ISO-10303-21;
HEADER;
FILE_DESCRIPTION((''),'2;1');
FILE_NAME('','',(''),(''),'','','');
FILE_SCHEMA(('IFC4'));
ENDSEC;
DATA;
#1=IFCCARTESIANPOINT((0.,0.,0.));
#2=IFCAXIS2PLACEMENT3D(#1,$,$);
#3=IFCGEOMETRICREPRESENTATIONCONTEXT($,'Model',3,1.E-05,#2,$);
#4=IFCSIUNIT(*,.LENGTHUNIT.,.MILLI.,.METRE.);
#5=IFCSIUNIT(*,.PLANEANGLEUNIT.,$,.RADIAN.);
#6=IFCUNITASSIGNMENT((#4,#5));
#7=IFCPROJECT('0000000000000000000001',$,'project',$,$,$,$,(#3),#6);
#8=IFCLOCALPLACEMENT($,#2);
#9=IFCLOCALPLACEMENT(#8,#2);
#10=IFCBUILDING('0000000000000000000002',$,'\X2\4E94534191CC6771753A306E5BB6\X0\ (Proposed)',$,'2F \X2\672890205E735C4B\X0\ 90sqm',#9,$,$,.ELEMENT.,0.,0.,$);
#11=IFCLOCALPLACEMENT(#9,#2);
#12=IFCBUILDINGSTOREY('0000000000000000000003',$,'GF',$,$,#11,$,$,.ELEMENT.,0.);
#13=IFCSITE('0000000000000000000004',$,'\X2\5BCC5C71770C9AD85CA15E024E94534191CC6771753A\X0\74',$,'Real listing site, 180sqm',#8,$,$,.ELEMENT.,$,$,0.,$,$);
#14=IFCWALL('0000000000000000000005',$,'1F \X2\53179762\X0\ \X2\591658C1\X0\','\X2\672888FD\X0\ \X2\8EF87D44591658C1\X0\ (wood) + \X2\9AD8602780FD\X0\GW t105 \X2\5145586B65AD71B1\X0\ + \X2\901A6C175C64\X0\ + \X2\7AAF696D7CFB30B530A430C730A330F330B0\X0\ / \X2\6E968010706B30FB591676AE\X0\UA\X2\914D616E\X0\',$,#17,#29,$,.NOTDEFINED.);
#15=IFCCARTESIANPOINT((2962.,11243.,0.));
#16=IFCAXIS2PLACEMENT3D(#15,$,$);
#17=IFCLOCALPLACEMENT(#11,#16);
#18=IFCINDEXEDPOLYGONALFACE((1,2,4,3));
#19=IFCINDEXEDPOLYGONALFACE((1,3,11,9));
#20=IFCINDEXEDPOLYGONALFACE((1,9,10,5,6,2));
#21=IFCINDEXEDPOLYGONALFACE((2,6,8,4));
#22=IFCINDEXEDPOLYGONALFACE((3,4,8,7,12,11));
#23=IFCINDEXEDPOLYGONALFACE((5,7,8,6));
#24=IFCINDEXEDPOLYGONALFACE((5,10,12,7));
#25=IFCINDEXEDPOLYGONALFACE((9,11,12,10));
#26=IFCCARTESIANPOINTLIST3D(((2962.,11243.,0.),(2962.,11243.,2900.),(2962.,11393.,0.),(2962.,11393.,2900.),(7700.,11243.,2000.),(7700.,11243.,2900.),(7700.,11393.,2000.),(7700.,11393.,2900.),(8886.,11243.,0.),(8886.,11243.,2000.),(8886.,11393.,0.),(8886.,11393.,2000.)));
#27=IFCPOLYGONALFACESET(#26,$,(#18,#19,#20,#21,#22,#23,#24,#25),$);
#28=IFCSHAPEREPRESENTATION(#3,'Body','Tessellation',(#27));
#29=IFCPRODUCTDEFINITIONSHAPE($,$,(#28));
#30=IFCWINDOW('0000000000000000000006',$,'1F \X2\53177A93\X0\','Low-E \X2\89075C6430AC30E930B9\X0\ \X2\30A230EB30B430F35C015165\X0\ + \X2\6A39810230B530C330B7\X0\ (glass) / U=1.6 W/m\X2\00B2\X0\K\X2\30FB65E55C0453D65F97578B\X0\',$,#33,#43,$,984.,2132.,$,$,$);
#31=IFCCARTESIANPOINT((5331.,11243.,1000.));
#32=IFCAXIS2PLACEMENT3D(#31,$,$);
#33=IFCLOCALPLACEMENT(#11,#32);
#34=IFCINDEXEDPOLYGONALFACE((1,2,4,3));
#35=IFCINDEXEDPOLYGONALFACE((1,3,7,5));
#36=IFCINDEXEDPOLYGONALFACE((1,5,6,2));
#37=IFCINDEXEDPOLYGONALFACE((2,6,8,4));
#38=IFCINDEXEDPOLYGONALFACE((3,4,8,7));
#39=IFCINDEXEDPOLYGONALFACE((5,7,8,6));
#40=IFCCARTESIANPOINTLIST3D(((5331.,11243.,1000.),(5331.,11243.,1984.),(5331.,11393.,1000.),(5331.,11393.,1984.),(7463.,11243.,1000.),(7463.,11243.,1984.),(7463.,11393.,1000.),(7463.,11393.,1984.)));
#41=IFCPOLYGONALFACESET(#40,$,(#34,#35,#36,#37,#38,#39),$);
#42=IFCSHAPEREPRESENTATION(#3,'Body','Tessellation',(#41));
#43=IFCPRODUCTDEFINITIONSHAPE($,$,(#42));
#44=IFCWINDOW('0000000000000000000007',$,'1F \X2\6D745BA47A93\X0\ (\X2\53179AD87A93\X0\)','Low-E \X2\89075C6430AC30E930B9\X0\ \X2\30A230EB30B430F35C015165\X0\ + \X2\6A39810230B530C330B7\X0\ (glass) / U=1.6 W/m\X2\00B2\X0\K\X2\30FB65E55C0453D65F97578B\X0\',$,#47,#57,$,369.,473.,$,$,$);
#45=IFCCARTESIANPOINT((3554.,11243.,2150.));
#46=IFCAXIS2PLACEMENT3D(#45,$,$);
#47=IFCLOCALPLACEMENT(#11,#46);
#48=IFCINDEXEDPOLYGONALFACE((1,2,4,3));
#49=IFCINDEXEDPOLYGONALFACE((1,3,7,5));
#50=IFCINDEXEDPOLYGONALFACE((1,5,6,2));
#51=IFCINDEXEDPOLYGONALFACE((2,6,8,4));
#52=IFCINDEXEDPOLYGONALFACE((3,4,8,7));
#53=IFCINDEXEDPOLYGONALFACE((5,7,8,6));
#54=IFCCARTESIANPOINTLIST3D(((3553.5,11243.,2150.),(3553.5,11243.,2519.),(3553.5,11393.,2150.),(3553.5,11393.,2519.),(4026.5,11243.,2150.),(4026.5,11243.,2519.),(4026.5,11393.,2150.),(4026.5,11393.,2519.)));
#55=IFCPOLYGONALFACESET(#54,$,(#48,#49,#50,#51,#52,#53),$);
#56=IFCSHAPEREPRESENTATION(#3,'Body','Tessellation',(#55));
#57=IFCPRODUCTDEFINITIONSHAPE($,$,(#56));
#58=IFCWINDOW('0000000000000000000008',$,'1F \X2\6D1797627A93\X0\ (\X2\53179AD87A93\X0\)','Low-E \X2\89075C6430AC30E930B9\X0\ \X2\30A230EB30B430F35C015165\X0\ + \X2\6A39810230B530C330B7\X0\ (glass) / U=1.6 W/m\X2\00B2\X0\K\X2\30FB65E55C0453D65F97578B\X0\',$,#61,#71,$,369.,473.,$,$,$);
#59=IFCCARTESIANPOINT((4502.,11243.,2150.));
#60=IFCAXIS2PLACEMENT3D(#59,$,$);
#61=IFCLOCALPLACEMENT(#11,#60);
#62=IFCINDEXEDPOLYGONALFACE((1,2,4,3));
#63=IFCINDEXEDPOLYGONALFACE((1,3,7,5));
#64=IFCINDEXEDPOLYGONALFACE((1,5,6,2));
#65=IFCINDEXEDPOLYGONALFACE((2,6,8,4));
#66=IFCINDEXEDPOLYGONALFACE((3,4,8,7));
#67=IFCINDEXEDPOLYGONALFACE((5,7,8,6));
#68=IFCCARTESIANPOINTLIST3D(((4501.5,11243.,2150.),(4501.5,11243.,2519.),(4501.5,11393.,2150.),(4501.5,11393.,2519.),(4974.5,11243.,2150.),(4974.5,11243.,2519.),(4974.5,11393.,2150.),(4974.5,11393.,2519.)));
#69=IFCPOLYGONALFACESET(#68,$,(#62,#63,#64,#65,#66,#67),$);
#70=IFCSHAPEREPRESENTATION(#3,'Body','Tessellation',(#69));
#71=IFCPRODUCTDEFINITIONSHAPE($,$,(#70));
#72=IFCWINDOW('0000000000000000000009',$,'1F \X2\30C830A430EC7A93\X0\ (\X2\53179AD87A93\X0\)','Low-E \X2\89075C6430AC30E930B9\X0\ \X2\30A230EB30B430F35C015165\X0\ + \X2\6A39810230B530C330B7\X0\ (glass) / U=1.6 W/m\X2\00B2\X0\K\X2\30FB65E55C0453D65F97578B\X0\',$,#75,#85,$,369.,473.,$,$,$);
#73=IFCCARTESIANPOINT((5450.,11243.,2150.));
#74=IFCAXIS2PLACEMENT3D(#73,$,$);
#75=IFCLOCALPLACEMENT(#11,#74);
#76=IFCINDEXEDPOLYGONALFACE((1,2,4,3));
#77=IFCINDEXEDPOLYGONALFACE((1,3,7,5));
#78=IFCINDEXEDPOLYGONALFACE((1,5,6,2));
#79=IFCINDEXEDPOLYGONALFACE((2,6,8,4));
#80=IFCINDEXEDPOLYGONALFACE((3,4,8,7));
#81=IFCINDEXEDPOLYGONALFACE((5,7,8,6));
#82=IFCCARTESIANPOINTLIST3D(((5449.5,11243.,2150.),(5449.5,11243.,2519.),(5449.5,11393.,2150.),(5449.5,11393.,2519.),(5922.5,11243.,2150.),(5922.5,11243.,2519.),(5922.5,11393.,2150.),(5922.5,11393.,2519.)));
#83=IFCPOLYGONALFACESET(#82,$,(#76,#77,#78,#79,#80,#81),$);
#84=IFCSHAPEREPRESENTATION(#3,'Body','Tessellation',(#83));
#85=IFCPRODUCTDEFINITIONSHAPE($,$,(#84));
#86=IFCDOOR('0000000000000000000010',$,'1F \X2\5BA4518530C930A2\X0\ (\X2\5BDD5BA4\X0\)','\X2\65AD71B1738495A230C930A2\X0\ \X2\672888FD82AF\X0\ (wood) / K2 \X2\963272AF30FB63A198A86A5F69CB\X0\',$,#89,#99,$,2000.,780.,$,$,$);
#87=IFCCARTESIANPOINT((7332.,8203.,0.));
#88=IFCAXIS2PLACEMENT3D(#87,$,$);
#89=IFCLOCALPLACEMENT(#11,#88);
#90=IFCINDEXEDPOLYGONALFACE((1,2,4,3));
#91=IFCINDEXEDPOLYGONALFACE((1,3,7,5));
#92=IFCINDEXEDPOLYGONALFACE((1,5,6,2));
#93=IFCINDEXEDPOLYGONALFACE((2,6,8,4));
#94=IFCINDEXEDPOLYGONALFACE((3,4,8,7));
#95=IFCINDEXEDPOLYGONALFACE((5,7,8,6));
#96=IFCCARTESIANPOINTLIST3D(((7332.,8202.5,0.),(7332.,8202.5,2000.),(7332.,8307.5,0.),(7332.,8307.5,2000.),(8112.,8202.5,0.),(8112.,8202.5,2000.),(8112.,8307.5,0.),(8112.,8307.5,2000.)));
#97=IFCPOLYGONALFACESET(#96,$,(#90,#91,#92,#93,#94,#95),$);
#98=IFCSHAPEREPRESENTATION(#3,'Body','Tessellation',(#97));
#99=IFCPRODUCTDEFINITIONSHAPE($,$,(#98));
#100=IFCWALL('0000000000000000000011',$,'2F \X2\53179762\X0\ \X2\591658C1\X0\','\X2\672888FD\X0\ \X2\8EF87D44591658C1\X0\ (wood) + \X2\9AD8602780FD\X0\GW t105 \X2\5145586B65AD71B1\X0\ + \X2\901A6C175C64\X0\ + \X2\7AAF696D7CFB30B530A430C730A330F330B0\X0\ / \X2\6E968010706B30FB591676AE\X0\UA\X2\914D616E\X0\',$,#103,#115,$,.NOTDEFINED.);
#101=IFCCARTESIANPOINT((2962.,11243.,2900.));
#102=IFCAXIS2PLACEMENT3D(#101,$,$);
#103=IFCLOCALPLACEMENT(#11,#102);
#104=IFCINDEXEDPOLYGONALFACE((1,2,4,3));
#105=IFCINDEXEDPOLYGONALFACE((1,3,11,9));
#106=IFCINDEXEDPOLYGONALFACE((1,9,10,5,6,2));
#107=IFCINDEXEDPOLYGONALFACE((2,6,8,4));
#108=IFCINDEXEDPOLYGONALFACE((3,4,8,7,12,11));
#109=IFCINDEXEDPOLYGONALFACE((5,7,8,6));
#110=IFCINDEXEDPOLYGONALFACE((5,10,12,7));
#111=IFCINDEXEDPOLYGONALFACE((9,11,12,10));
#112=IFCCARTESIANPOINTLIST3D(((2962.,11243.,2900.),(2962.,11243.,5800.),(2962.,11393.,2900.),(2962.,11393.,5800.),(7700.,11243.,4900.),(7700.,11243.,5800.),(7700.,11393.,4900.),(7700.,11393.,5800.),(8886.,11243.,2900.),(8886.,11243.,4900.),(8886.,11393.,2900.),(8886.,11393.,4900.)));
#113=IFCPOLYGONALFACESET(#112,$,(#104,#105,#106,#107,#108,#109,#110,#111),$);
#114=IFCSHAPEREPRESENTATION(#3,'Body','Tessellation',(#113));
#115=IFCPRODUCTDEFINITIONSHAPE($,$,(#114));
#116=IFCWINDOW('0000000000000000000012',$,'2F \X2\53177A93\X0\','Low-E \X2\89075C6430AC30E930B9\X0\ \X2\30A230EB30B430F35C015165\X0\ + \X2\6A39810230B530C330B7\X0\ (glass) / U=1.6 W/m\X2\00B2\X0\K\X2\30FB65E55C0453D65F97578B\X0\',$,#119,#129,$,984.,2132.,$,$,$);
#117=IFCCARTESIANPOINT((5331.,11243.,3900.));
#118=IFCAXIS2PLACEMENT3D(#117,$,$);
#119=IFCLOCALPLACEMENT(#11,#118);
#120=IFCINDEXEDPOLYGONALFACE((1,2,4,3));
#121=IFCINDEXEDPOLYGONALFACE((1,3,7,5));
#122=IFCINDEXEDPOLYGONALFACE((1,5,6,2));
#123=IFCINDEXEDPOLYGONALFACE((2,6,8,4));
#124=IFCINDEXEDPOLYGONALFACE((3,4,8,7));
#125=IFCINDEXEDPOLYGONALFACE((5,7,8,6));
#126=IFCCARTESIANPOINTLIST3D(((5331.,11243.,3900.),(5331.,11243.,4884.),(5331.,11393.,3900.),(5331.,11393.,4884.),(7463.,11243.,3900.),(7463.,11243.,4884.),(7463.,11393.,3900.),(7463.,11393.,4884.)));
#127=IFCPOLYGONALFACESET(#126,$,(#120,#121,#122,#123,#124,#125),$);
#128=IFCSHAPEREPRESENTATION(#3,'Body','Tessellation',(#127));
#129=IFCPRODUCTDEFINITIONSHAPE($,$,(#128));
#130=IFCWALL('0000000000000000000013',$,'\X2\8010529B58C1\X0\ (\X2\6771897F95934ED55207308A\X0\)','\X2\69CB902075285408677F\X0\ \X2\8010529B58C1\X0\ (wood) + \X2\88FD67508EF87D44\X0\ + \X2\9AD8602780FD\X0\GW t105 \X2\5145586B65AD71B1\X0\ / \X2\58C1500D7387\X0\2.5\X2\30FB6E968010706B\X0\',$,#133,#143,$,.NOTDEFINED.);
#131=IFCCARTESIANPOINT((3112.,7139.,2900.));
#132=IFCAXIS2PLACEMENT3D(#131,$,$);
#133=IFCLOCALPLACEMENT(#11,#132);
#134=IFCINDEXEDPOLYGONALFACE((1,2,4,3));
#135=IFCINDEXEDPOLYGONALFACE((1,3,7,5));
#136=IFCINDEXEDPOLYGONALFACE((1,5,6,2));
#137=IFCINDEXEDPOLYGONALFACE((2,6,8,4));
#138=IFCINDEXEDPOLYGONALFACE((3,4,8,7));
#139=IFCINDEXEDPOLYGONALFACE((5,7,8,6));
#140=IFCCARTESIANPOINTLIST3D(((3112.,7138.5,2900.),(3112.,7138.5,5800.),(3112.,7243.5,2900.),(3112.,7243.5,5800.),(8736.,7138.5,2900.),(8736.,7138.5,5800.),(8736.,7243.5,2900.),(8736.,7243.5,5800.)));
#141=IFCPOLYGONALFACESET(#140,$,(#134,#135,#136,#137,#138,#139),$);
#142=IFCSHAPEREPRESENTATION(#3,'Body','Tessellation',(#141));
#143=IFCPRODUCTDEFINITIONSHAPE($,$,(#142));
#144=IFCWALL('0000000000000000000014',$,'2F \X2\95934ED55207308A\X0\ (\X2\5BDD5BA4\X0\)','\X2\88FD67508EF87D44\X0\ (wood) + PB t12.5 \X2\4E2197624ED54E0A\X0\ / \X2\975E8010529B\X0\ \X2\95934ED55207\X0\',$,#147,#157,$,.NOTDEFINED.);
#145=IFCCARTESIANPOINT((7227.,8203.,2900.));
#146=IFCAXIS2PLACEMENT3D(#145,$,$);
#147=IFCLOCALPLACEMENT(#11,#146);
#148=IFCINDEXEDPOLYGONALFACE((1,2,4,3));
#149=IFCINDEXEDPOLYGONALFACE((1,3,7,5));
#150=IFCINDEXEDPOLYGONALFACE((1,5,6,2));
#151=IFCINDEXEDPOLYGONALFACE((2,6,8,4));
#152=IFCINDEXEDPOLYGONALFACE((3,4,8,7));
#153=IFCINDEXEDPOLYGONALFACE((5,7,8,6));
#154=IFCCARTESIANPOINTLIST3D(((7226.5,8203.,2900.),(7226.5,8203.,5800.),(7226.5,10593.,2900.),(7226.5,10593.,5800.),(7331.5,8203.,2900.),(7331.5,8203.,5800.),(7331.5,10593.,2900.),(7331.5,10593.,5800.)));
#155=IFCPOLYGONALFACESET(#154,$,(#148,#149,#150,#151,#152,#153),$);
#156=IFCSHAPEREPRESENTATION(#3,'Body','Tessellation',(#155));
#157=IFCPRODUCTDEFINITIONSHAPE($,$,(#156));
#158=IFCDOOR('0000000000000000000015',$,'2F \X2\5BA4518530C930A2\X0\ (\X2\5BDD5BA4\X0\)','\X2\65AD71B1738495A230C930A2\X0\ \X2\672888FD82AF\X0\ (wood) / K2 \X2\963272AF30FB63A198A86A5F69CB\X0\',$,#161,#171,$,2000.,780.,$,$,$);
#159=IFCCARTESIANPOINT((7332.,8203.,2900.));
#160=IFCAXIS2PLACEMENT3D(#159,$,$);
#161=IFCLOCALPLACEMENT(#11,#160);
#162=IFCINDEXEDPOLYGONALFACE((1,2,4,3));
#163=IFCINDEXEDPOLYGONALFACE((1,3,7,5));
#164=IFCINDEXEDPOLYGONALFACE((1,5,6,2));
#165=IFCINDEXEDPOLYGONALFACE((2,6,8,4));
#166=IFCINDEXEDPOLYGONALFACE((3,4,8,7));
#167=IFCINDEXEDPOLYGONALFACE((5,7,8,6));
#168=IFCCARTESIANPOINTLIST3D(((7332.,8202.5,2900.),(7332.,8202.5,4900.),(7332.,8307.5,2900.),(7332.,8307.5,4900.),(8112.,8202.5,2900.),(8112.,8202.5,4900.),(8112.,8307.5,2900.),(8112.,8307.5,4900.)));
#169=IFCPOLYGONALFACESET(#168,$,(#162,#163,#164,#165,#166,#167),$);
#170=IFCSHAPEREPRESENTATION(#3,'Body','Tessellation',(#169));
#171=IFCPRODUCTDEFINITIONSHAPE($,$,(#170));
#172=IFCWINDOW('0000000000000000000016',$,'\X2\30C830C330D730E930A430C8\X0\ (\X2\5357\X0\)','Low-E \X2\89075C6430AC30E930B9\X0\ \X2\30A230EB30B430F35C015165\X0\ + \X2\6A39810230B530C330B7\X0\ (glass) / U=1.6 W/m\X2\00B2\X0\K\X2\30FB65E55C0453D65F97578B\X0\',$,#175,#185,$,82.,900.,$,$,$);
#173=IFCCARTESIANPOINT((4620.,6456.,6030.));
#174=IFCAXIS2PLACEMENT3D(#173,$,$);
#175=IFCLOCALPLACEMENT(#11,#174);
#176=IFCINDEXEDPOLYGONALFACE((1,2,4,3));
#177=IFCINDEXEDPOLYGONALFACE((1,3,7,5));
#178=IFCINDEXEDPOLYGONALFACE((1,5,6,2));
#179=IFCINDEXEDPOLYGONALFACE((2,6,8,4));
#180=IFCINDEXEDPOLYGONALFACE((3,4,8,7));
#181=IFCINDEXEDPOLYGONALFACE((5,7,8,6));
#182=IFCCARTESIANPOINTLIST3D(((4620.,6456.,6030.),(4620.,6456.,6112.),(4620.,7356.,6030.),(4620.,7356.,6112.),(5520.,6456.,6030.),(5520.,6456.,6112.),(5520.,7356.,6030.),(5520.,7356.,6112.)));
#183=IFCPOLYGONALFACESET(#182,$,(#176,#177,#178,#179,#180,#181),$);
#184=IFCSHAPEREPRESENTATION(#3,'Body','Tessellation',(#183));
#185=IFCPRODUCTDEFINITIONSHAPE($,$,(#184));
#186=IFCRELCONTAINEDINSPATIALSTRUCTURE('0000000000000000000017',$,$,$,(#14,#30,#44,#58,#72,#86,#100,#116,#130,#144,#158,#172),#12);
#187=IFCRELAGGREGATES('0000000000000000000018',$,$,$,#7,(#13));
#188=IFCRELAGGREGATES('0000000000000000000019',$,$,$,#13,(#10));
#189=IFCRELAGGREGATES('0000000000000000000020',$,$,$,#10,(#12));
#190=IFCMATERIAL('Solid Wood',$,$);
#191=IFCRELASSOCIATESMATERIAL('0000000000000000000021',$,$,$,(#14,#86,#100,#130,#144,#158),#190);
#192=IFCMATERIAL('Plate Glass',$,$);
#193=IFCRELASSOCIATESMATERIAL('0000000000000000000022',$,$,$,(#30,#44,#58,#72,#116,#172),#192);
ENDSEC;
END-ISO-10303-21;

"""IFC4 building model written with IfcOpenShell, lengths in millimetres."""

from ifc_helpers import new_model, si_unit, frame, frame_2d, origin, place, context, project, spatial, rectangle, extrude, material, element, fill, save


model = new_model("IFC4")

# Units and contexts
model_context = context("Model", 3, precision=1e-05, world=origin())
ifc_project = project(units=[si_unit("LENGTHUNIT", "METRE", prefix="MILLI"), si_unit("PLANEANGLEUNIT", "RADIAN")], contexts=[model_context])

# Site, building, storey
site_placement = place(None, origin())
site = spatial("IfcSite", under=ifc_project, at=site_placement, Name="富山県高岡市五十里東町74", ObjectType="Real listing site, 180sqm", CompositionType="ELEMENT", RefElevation=0.0)
building_placement = place(site_placement, origin())
building = spatial("IfcBuilding", under=site, at=building_placement, Name="五十里東町の家 (Proposed)", ObjectType="2F 木造平屋 90sqm", CompositionType="ELEMENT", ElevationOfRefHeight=0.0, ElevationOfTerrain=0.0)
storey_placement = place(building_placement, origin())
storey = spatial("IfcBuildingStorey", under=building, at=storey_placement, Name="GF", CompositionType="ELEMENT", Elevation=0.0)

# Wall, openings, windows
ifc_material_1 = material(Name="Solid Wood")
wall_1_placement = place(storey_placement, frame((2962.0, 11243.0, 0.0)))
wall_1 = element("IfcWall", 1, at=wall_1_placement, inside=storey, material=ifc_material_1, Name="1F 北面 外壁", Description="木製 軸組外壁 (wood) + 高性能GW t105 充填断熱 + 通気層 + 窯業系サイディング / 準耐火・外皮UA配慮", PredefinedType="NOTDEFINED", context=model_context, shape_type="SweptSolid", body=[
    extrude(rectangle(XDim=5924.0, YDim=150.0, at=frame_2d((2962.0, 75.0))), frame((2962.0, 11243.0, 0.0)), (0.0, 0.0, 1.0), 2900.0),
])
opening_1_placement = place(storey_placement, frame((5331.0, 11243.0, 1000.0)))
opening_1 = element("IfcOpeningElement", 2, at=opening_1_placement, cuts=wall_1, PredefinedType="NOTDEFINED", context=model_context, shape_type="SweptSolid", body=[
    extrude(rectangle(XDim=2132.0, YDim=150.0, at=frame_2d((1066.0, 75.0))), frame((5331.0, 11243.0, 1000.0)), (0.0, 0.0, 1.0), 984.0),
])
opening_2_placement = place(storey_placement, frame((3554.0, 11243.0, 2150.0)))
opening_2 = element("IfcOpeningElement", 3, at=opening_2_placement, cuts=wall_1, PredefinedType="NOTDEFINED", context=model_context, shape_type="SweptSolid", body=[
    extrude(rectangle(XDim=473.0, YDim=150.0, at=frame_2d((236.0, 75.0))), frame((3554.0, 11243.0, 2150.0)), (0.0, 0.0, 1.0), 369.0),
])
opening_3_placement = place(storey_placement, frame((4502.0, 11243.0, 2150.0)))
opening_3 = element("IfcOpeningElement", 4, at=opening_3_placement, cuts=wall_1, PredefinedType="NOTDEFINED", context=model_context, shape_type="SweptSolid", body=[
    extrude(rectangle(XDim=473.0, YDim=150.0, at=frame_2d((236.0, 75.0))), frame((4502.0, 11243.0, 2150.0)), (0.0, 0.0, 1.0), 369.0),
])
opening_4_placement = place(storey_placement, frame((5450.0, 11243.0, 2150.0)))
opening_4 = element("IfcOpeningElement", 5, at=opening_4_placement, cuts=wall_1, PredefinedType="NOTDEFINED", context=model_context, shape_type="SweptSolid", body=[
    extrude(rectangle(XDim=473.0, YDim=150.0, at=frame_2d((236.0, 75.0))), frame((5450.0, 11243.0, 2150.0)), (0.0, 0.0, 1.0), 369.0),
])
ifc_material_2 = material(Name="Plate Glass")
window_1_placement = place(storey_placement, frame((5331.0, 11243.0, 1000.0)))
window_1 = element("IfcWindow", 6, at=window_1_placement, inside=storey, material=ifc_material_2, Name="1F 北窓", Description="Low-E 複層ガラス アルゴン封入 + 樹脂サッシ (glass) / U=1.6 W/m²K・日射取得型", OverallHeight=984.0, OverallWidth=2132.0, context=model_context, shape_type="SweptSolid", body=[
    extrude(rectangle(XDim=2132.0, YDim=150.0, at=frame_2d((1066.0, 75.0))), frame((5331.0, 11243.0, 1000.0)), (0.0, 0.0, 1.0), 984.0),
])
fill(opening_1, window_1)
window_2_placement = place(storey_placement, frame((3554.0, 11243.0, 2150.0)))
window_2 = element("IfcWindow", 7, at=window_2_placement, inside=storey, material=ifc_material_2, Name="1F 浴室窓 (北高窓)", Description="Low-E 複層ガラス アルゴン封入 + 樹脂サッシ (glass) / U=1.6 W/m²K・日射取得型", OverallHeight=369.0, OverallWidth=473.0, context=model_context, shape_type="SweptSolid", body=[
    extrude(rectangle(XDim=473.0, YDim=150.0, at=frame_2d((236.0, 75.0))), frame((3554.0, 11243.0, 2150.0)), (0.0, 0.0, 1.0), 369.0),
])
fill(opening_2, window_2)
window_3_placement = place(storey_placement, frame((4502.0, 11243.0, 2150.0)))
window_3 = element("IfcWindow", 8, at=window_3_placement, inside=storey, material=ifc_material_2, Name="1F 洗面窓 (北高窓)", Description="Low-E 複層ガラス アルゴン封入 + 樹脂サッシ (glass) / U=1.6 W/m²K・日射取得型", OverallHeight=369.0, OverallWidth=473.0, context=model_context, shape_type="SweptSolid", body=[
    extrude(rectangle(XDim=473.0, YDim=150.0, at=frame_2d((236.0, 75.0))), frame((4502.0, 11243.0, 2150.0)), (0.0, 0.0, 1.0), 369.0),
])
fill(opening_3, window_3)
window_4_placement = place(storey_placement, frame((5450.0, 11243.0, 2150.0)))
window_4 = element("IfcWindow", 9, at=window_4_placement, inside=storey, material=ifc_material_2, Name="1F トイレ窓 (北高窓)", Description="Low-E 複層ガラス アルゴン封入 + 樹脂サッシ (glass) / U=1.6 W/m²K・日射取得型", OverallHeight=369.0, OverallWidth=473.0, context=model_context, shape_type="SweptSolid", body=[
    extrude(rectangle(XDim=473.0, YDim=150.0, at=frame_2d((236.0, 75.0))), frame((5450.0, 11243.0, 2150.0)), (0.0, 0.0, 1.0), 369.0),
])
fill(opening_4, window_4)

# Door
door_1_placement = place(storey_placement, frame((7332.0, 8203.0, 0.0)))
element("IfcDoor", 10, at=door_1_placement, inside=storey, material=ifc_material_1, Name="1F 室内ドア (寝室)", Description="断熱玄関ドア 木製芯 (wood) / K2 防犯・採風機構", OverallHeight=2000.0, OverallWidth=780.0, context=model_context, shape_type="SweptSolid", body=[
    extrude(rectangle(XDim=780.0, YDim=105.0, at=frame_2d((390.0, 52.0))), frame((7332.0, 8203.0, 0.0)), (0.0, 0.0, 1.0), 2000.0),
])

# Wall, opening, window
wall_2_placement = place(storey_placement, frame((2962.0, 11243.0, 2900.0)))
wall_2 = element("IfcWall", 11, at=wall_2_placement, inside=storey, material=ifc_material_1, Name="2F 北面 外壁", Description="木製 軸組外壁 (wood) + 高性能GW t105 充填断熱 + 通気層 + 窯業系サイディング / 準耐火・外皮UA配慮", PredefinedType="NOTDEFINED", context=model_context, shape_type="SweptSolid", body=[
    extrude(rectangle(XDim=5924.0, YDim=150.0, at=frame_2d((2962.0, 75.0))), frame((2962.0, 11243.0, 2900.0)), (0.0, 0.0, 1.0), 2900.0),
])
opening_5_placement = place(storey_placement, frame((5331.0, 11243.0, 3900.0)))
opening_5 = element("IfcOpeningElement", 12, at=opening_5_placement, cuts=wall_2, PredefinedType="NOTDEFINED", context=model_context, shape_type="SweptSolid", body=[
    extrude(rectangle(XDim=2132.0, YDim=150.0, at=frame_2d((1066.0, 75.0))), frame((5331.0, 11243.0, 3900.0)), (0.0, 0.0, 1.0), 984.0),
])
window_5_placement = place(storey_placement, frame((5331.0, 11243.0, 3900.0)))
window_5 = element("IfcWindow", 13, at=window_5_placement, inside=storey, material=ifc_material_2, Name="2F 北窓", Description="Low-E 複層ガラス アルゴン封入 + 樹脂サッシ (glass) / U=1.6 W/m²K・日射取得型", OverallHeight=984.0, OverallWidth=2132.0, context=model_context, shape_type="SweptSolid", body=[
    extrude(rectangle(XDim=2132.0, YDim=150.0, at=frame_2d((1066.0, 75.0))), frame((5331.0, 11243.0, 3900.0)), (0.0, 0.0, 1.0), 984.0),
])
fill(opening_5, window_5)

# Walls
wall_3_placement = place(storey_placement, frame((3112.0, 7139.0, 2900.0)))
element("IfcWall", 14, at=wall_3_placement, inside=storey, material=ifc_material_1, Name="耐力壁 (東西間仕切り)", Description="構造用合板 耐力壁 (wood) + 製材軸組 + 高性能GW t105 充填断熱 / 壁倍率2.5・準耐火", PredefinedType="NOTDEFINED", context=model_context, shape_type="SweptSolid", body=[
    extrude(rectangle(XDim=5624.0, YDim=105.0, at=frame_2d((2812.0, 52.0))), frame((3112.0, 7139.0, 2900.0)), (0.0, 0.0, 1.0), 2900.0),
])
wall_4_placement = place(storey_placement, frame((7227.0, 8203.0, 2900.0)))
element("IfcWall", 15, at=wall_4_placement, inside=storey, material=ifc_material_1, Name="2F 間仕切り (寝室)", Description="製材軸組 (wood) + PB t12.5 両面仕上 / 非耐力 間仕切", PredefinedType="NOTDEFINED", context=model_context, shape_type="SweptSolid", body=[
    extrude(rectangle(XDim=105.0, YDim=2390.0, at=frame_2d((52.0, 1195.0))), frame((7227.0, 8203.0, 2900.0)), (0.0, 0.0, 1.0), 2900.0),
])

# Door
door_2_placement = place(storey_placement, frame((7332.0, 8203.0, 2900.0)))
element("IfcDoor", 16, at=door_2_placement, inside=storey, material=ifc_material_1, Name="2F 室内ドア (寝室)", Description="断熱玄関ドア 木製芯 (wood) / K2 防犯・採風機構", OverallHeight=2000.0, OverallWidth=780.0, context=model_context, shape_type="SweptSolid", body=[
    extrude(rectangle(XDim=780.0, YDim=105.0, at=frame_2d((390.0, 52.0))), frame((7332.0, 8203.0, 2900.0)), (0.0, 0.0, 1.0), 2000.0),
])

# Window
window_6_placement = place(storey_placement, frame((4620.0, 6456.0, 6030.0)))
element("IfcWindow", 17, at=window_6_placement, inside=storey, material=ifc_material_2, Name="トップライト (南)", Description="Low-E 複層ガラス アルゴン封入 + 樹脂サッシ (glass) / U=1.6 W/m²K・日射取得型", OverallHeight=82.0, OverallWidth=900.0, context=model_context, shape_type="SweptSolid", body=[
    extrude(rectangle(XDim=900.0, YDim=900.0, at=frame_2d((450.0, 450.0))), frame((4620.0, 6456.0, 6030.0)), (0.0, 0.0, 1.0), 82.0),
])

save(model, "model.ifc")
